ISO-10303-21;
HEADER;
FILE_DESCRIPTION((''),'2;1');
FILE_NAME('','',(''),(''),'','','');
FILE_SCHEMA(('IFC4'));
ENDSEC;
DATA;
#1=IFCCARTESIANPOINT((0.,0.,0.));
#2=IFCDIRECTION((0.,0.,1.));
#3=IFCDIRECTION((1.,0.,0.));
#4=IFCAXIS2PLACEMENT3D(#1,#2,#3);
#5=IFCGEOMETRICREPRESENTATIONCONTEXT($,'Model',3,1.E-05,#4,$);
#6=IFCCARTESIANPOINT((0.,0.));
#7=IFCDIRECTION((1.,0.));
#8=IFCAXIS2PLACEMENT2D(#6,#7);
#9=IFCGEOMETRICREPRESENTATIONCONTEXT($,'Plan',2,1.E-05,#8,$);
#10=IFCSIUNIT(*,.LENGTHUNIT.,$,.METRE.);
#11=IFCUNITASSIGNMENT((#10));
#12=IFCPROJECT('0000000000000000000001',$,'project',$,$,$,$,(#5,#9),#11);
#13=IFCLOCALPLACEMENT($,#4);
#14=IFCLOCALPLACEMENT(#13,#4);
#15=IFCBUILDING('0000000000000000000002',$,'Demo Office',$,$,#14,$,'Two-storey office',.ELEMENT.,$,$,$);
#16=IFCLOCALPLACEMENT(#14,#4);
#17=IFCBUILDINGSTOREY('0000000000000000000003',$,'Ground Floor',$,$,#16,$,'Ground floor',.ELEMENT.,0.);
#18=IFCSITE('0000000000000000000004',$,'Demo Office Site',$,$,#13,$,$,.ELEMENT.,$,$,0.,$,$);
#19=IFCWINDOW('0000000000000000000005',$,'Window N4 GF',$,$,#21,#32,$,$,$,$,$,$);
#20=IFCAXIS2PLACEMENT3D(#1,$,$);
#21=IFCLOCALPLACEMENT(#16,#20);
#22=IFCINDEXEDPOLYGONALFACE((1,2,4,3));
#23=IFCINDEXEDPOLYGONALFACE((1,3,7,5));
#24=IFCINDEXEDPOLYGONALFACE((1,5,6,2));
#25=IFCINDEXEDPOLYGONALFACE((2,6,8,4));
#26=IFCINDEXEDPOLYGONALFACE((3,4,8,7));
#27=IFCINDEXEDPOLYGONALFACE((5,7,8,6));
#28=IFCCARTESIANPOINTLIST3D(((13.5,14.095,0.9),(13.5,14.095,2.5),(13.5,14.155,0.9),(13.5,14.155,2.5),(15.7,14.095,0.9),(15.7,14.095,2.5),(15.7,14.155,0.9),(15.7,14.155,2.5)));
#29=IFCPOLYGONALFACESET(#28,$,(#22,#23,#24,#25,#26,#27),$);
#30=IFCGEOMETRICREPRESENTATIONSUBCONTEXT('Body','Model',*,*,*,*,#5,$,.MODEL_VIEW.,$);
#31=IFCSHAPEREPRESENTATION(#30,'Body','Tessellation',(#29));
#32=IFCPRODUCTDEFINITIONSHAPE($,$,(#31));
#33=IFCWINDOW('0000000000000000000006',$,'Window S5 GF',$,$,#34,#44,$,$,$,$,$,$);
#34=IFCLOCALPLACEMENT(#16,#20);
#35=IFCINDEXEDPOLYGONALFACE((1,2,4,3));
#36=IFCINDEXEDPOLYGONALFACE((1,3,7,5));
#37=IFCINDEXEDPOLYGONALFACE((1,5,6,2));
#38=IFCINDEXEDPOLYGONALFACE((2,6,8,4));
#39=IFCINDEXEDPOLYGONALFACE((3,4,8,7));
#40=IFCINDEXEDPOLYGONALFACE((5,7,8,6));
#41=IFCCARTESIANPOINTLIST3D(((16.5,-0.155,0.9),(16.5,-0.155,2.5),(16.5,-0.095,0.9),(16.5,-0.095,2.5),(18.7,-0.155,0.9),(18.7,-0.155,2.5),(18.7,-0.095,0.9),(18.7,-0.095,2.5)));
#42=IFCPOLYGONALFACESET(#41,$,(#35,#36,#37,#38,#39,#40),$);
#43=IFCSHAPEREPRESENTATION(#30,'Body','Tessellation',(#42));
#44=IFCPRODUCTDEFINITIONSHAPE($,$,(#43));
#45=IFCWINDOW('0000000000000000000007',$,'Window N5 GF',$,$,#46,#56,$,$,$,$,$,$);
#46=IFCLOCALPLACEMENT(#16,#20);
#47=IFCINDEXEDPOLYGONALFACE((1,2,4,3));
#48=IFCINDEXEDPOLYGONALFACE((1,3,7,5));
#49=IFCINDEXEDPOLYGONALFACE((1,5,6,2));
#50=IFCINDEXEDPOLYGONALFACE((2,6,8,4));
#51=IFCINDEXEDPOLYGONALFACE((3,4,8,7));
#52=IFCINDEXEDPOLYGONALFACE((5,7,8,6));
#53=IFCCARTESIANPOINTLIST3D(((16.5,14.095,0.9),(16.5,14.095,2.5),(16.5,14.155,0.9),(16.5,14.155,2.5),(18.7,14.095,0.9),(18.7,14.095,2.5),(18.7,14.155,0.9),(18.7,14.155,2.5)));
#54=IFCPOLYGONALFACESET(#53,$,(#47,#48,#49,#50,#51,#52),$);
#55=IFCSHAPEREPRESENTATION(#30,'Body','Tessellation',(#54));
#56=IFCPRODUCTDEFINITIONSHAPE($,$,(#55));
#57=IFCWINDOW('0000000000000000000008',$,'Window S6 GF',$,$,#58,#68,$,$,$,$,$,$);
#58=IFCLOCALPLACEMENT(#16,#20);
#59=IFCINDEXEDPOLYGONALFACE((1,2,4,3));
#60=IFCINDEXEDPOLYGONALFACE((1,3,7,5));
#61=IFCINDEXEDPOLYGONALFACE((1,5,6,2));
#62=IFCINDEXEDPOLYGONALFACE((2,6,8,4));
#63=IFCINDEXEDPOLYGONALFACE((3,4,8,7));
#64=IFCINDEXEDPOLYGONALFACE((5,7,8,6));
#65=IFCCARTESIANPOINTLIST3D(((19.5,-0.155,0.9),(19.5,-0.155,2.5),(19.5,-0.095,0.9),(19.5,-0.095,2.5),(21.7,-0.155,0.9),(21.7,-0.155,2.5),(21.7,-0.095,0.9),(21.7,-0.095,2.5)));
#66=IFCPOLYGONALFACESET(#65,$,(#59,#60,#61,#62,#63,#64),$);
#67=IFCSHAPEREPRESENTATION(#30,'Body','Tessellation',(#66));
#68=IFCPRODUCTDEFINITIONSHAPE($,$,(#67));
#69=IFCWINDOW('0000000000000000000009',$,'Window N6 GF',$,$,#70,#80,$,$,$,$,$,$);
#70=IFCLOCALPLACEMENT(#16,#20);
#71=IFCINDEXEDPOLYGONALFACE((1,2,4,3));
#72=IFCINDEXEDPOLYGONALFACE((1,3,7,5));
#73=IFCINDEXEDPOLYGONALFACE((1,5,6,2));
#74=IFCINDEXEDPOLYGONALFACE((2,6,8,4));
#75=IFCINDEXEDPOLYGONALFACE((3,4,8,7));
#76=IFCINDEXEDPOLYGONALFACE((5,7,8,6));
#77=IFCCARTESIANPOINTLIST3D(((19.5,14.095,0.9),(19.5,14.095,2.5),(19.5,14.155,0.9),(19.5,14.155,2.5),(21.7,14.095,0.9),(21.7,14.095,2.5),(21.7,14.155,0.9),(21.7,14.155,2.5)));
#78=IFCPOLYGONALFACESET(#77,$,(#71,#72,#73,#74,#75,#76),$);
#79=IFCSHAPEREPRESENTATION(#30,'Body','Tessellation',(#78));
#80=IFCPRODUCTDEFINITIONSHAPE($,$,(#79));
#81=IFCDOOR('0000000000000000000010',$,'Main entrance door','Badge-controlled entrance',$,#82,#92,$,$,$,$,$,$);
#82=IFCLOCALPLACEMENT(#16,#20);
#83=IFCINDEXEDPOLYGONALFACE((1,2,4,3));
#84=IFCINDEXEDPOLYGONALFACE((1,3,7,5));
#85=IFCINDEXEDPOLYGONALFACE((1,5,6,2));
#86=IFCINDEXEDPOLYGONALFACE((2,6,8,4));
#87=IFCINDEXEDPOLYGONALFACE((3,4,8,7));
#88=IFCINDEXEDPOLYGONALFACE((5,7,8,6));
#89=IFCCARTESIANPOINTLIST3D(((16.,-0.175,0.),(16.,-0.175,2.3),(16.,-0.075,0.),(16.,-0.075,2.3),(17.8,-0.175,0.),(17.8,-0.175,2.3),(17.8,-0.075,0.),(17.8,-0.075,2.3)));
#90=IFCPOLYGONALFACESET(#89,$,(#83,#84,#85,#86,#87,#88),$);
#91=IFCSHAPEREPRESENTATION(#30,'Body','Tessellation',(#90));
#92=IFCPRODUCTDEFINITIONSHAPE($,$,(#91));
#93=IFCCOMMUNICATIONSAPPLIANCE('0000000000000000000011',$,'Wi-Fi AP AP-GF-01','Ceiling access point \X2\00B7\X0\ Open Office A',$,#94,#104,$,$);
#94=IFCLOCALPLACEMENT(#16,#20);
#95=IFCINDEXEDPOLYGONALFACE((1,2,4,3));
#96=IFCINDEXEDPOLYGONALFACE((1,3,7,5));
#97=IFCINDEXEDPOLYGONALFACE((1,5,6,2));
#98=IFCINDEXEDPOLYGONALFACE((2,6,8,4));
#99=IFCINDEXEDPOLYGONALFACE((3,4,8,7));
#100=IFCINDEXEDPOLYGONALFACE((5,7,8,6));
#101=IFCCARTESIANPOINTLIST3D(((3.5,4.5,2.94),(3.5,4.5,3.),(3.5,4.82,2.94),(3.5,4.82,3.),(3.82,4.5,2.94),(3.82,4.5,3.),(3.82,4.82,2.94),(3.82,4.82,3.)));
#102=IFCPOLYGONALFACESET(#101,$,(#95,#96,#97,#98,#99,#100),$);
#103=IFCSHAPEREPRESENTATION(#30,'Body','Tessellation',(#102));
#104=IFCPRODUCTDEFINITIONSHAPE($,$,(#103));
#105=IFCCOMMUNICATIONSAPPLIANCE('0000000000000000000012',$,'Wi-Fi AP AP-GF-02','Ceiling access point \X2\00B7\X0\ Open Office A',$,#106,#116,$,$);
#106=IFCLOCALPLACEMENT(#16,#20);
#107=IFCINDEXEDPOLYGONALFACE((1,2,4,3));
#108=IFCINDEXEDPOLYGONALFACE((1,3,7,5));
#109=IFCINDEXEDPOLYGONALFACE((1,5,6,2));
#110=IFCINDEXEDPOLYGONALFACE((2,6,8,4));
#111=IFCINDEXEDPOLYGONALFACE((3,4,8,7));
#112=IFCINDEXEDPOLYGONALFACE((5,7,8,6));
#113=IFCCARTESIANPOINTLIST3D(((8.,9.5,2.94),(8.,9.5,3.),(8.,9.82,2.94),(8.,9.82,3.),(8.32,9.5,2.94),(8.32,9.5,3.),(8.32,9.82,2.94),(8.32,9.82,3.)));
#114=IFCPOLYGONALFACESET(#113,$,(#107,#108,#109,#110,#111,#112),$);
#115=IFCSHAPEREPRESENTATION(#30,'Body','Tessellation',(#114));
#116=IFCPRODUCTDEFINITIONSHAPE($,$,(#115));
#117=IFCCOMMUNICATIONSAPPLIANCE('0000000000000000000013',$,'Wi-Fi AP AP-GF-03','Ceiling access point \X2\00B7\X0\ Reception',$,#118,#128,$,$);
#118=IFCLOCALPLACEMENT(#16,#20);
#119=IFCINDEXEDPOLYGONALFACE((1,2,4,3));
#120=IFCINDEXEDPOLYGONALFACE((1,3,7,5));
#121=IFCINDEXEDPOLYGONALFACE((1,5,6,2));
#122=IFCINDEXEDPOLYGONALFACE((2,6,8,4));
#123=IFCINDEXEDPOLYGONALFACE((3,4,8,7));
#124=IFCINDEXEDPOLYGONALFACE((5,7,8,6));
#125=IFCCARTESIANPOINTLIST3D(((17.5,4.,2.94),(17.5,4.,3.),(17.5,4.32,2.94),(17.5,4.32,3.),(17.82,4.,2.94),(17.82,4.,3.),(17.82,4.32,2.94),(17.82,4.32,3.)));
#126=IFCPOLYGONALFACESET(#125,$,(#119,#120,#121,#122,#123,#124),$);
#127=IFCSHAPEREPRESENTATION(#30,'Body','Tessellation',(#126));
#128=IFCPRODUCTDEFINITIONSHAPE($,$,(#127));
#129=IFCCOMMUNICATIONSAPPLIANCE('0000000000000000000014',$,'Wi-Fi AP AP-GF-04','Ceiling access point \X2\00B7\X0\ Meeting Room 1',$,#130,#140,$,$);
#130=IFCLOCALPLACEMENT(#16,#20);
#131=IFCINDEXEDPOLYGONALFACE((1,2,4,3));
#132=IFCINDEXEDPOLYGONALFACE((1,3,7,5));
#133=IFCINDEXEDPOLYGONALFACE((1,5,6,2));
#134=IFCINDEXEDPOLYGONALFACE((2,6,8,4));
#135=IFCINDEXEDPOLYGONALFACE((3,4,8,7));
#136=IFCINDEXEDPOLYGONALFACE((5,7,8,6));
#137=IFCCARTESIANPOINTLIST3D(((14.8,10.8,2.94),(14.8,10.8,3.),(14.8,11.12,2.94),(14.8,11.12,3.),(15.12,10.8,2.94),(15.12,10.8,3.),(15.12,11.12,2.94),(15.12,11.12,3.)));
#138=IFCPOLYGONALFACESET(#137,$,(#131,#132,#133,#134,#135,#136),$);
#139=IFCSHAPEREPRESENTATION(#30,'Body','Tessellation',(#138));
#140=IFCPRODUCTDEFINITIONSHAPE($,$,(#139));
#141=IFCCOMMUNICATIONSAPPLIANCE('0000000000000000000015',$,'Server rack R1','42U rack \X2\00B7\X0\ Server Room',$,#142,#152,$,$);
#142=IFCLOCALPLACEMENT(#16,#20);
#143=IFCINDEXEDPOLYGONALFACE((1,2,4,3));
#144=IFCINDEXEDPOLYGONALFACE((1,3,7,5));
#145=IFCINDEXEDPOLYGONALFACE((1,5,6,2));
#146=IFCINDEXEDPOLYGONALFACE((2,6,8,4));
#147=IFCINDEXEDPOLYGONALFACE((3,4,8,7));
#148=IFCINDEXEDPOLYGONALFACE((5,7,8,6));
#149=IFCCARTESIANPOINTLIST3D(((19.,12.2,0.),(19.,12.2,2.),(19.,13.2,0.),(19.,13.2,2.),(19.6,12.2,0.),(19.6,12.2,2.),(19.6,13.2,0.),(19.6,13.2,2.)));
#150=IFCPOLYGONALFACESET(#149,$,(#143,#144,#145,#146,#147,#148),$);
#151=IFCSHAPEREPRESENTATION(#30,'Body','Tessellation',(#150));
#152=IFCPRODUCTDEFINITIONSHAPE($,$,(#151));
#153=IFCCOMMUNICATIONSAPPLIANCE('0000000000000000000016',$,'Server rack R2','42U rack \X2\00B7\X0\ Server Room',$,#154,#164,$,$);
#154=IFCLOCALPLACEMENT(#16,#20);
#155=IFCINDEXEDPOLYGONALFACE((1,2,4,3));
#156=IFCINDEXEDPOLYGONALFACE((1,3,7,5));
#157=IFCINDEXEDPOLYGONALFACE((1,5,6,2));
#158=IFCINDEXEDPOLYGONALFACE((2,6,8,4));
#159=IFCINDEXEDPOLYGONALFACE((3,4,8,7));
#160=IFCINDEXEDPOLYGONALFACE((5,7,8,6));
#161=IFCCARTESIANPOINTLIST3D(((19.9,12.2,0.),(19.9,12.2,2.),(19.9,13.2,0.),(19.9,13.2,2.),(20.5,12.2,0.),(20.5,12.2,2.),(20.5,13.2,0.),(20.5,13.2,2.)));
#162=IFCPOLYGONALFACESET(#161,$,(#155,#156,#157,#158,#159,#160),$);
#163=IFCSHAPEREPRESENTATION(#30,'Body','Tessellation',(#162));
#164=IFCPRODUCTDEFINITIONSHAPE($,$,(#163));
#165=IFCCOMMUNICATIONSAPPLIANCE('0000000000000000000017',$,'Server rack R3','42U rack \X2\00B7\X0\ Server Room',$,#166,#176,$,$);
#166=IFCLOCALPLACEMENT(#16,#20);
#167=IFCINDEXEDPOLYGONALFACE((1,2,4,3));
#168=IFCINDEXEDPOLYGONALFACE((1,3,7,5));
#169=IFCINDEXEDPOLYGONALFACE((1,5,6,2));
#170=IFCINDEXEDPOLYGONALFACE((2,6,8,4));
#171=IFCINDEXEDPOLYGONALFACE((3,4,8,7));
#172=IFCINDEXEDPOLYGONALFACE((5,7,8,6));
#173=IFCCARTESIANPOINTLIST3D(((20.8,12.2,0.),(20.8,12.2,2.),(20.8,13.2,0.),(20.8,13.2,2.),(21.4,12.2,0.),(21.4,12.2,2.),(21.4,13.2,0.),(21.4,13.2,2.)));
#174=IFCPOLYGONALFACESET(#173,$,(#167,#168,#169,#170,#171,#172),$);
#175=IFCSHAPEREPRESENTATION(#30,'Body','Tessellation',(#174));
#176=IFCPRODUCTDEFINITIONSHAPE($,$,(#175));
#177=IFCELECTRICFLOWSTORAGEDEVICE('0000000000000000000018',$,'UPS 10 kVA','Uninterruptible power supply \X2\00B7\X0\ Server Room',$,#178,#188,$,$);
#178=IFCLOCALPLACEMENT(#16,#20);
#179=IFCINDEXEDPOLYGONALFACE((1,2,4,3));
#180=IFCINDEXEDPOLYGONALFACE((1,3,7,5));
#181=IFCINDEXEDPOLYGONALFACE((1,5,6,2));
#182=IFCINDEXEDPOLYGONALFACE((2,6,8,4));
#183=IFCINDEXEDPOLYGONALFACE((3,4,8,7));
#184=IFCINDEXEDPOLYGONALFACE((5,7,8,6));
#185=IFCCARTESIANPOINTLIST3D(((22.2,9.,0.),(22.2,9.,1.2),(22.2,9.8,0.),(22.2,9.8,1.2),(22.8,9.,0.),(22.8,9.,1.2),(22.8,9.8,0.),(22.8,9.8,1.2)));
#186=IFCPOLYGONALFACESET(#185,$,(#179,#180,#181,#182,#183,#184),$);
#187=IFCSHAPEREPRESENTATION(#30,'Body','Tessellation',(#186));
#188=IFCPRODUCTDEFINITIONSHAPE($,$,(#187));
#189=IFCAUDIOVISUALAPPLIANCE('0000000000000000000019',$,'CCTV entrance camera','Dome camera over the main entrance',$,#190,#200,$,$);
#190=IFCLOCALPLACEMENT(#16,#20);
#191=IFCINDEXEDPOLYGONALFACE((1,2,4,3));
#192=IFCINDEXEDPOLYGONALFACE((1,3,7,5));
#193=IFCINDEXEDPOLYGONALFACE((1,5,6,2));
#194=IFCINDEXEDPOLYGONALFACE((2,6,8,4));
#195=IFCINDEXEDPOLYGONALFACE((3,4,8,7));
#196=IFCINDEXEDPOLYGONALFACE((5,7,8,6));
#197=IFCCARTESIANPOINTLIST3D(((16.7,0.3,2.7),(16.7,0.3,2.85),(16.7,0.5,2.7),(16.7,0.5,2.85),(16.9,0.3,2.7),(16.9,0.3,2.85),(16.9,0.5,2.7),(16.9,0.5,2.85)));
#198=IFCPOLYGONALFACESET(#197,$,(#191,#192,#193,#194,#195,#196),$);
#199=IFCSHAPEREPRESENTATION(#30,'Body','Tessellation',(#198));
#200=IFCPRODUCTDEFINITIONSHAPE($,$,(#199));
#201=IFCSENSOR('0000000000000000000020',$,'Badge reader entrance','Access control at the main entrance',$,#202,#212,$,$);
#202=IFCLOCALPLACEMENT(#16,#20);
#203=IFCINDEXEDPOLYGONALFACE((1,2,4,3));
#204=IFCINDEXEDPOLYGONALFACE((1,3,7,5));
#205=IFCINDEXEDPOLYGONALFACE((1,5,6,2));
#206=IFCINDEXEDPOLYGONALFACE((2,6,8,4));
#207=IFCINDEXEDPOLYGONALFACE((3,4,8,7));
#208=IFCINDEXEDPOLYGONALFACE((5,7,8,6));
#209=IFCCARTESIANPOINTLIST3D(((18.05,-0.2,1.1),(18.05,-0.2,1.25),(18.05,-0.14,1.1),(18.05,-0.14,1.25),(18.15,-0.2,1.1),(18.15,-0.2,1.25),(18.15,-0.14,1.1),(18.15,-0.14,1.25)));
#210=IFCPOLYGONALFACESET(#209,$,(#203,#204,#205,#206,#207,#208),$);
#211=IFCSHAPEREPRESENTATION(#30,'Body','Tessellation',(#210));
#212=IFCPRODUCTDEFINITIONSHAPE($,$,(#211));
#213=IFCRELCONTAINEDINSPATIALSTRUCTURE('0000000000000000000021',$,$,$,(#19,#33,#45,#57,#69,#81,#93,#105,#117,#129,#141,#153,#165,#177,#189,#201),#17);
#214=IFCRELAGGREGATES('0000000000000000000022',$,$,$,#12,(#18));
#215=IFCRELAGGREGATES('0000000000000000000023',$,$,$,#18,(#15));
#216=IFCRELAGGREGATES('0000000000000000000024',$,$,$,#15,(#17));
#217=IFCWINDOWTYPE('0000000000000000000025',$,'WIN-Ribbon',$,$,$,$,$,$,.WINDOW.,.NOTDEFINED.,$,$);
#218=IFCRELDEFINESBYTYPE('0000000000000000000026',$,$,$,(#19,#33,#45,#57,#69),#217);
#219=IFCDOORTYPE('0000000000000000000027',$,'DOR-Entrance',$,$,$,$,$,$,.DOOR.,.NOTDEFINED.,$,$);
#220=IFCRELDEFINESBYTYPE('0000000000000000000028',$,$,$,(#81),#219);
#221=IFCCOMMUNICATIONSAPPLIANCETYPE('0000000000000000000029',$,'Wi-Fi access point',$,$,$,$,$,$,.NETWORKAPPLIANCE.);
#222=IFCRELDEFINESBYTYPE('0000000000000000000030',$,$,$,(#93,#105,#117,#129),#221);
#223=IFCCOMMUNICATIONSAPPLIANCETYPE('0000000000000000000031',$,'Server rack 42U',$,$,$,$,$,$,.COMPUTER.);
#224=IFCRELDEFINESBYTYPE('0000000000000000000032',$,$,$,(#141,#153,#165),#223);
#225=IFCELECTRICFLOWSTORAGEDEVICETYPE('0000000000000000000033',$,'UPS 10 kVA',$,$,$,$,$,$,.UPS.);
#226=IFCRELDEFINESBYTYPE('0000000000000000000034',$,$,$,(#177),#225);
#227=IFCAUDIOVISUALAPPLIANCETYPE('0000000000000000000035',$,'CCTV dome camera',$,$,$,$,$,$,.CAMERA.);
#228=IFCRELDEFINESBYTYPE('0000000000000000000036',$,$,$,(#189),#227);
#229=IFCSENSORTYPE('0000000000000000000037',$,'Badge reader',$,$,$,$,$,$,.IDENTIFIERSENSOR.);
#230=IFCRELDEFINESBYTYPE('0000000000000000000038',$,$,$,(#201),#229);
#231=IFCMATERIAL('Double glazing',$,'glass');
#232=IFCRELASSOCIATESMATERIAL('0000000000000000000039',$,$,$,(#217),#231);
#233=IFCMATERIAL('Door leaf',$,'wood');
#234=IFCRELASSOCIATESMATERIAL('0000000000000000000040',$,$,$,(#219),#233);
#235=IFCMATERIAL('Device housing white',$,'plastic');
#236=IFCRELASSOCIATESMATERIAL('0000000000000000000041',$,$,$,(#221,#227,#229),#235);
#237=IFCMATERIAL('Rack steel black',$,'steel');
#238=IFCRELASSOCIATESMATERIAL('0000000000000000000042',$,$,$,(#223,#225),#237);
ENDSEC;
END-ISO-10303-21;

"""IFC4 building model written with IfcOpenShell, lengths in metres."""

from ifc_helpers import new_model, si_unit, frame, origin_with_axes, origin_2d_with_axis, place, context, subcontext, project, spatial, line, indexed_curve, outline, extrude, material, type_object, element, save


model = new_model("IFC4")

# Units and contexts
model_context = context("Model", 3, precision=1e-05, world=origin_with_axes())
plan_context = context("Plan", 2, precision=1e-05, world=origin_2d_with_axis())
body_context = subcontext(model_context, "Body", "Model", "MODEL_VIEW")
ifc_project = project(units=[si_unit("LENGTHUNIT", "METRE")], contexts=[model_context, plan_context])

# Site, building, storey
site_placement = place(None, origin_with_axes())
site = spatial("IfcSite", under=ifc_project, at=site_placement, Name="Demo Office Site", CompositionType="ELEMENT", RefElevation=0.0)
building_placement = place(site_placement, origin_with_axes())
building = spatial("IfcBuilding", under=site, at=building_placement, Name="Demo Office", LongName="Two-storey office", CompositionType="ELEMENT")
storey_placement = place(building_placement, origin_with_axes())
storey = spatial("IfcBuildingStorey", under=building, at=storey_placement, Name="Ground Floor", LongName="Ground floor", CompositionType="ELEMENT", Elevation=0.0)

# Windows
ifc_material_1 = material(Name="Double glazing", Category="glass")
window_type = type_object("IfcWindowType", Name="WIN-Ribbon", PartitioningType="NOTDEFINED", PredefinedType="WINDOW", material=ifc_material_1)
for number, where, z_axis, x_axis, name in (
    (1, (13.5, 14.095, 0.9), (0.0, 0.0, 1.0), (1.0, 0.0, 0.0), "Window N4 GF"),
    (2, (16.5, -0.155, 0.9), (0.0, 0.0, 1.0), (1.0, 0.0, 0.0), "Window S5 GF"),
    (3, (16.5, 14.095, 0.9), (0.0, 0.0, 1.0), (1.0, 0.0, 0.0), "Window N5 GF"),
    (4, (19.5, -0.155, 0.9), (0.0, 0.0, 1.0), (1.0, 0.0, 0.0), "Window S6 GF"),
    (5, (19.5, 14.095, 0.9), (0.0, 0.0, 1.0), (1.0, 0.0, 0.0), "Window N6 GF"),
):
    element("IfcWindow", number, at=place(storey_placement, frame(where, z_axis=z_axis, x_axis=x_axis)), inside=storey, type_object=window_type, Name=name, context=body_context, shape_type="SweptSolid", body=[
        extrude(outline(indexed_curve([(0.0, 0.0), (2.2, 0.0), (2.2, 0.06), (0.0, 0.06)], segments=[line(1, 2, 3, 4, 1)])), origin_with_axes(), (0.0, 0.0, 1.0), 1.6),
    ])

# Door
ifc_material_2 = material(Name="Door leaf", Category="wood")
door_type = type_object("IfcDoorType", Name="DOR-Entrance", OperationType="NOTDEFINED", PredefinedType="DOOR", material=ifc_material_2)
door_placement = place(storey_placement, frame((16.0, -0.175, 0.0), z_axis=(0.0, 0.0, 1.0), x_axis=(1.0, 0.0, 0.0)))
element("IfcDoor", 6, at=door_placement, inside=storey, type_object=door_type, Name="Main entrance door", Description="Badge-controlled entrance", context=body_context, shape_type="SweptSolid", body=[
    extrude(outline(indexed_curve([(0.0, 0.0), (1.8, 0.0), (1.8, 0.1), (0.0, 0.1)], segments=[line(1, 2, 3, 4, 1)])), origin_with_axes(), (0.0, 0.0, 1.0), 2.3),
])

# Communications appliances
ifc_material_3 = material(Name="Device housing white", Category="plastic")
communications_appliance_type_1 = type_object("IfcCommunicationsApplianceType", Name="Wi-Fi access point", PredefinedType="NETWORKAPPLIANCE", material=ifc_material_3)
for number, where, z_axis, x_axis, name, description in (
    (7, (3.5, 4.5, 2.94), (0.0, 0.0, 1.0), (1.0, 0.0, 0.0), "Wi-Fi AP AP-GF-01", "Ceiling access point · Open Office A"),
    (8, (8.0, 9.5, 2.94), (0.0, 0.0, 1.0), (1.0, 0.0, 0.0), "Wi-Fi AP AP-GF-02", "Ceiling access point · Open Office A"),
    (9, (17.5, 4.0, 2.94), (0.0, 0.0, 1.0), (1.0, 0.0, 0.0), "Wi-Fi AP AP-GF-03", "Ceiling access point · Reception"),
    (10, (14.8, 10.8, 2.94), (0.0, 0.0, 1.0), (1.0, 0.0, 0.0), "Wi-Fi AP AP-GF-04", "Ceiling access point · Meeting Room 1"),
):
    element("IfcCommunicationsAppliance", number, at=place(storey_placement, frame(where, z_axis=z_axis, x_axis=x_axis)), inside=storey, type_object=communications_appliance_type_1, Name=name, Description=description, context=body_context, shape_type="SweptSolid", body=[
        extrude(outline(indexed_curve([(0.0, 0.0), (0.32, 0.0), (0.32, 0.32), (0.0, 0.32)], segments=[line(1, 2, 3, 4, 1)])), origin_with_axes(), (0.0, 0.0, 1.0), 0.06),
    ])
ifc_material_4 = material(Name="Rack steel black", Category="steel")
communications_appliance_type_2 = type_object("IfcCommunicationsApplianceType", Name="Server rack 42U", PredefinedType="COMPUTER", material=ifc_material_4)
for number, where, z_axis, x_axis, name in (
    (11, (19.0, 12.2, 0.0), (0.0, 0.0, 1.0), (1.0, 0.0, 0.0), "Server rack R1"),
    (12, (19.9, 12.2, 0.0), (0.0, 0.0, 1.0), (1.0, 0.0, 0.0), "Server rack R2"),
    (13, (20.8, 12.2, 0.0), (0.0, 0.0, 1.0), (1.0, 0.0, 0.0), "Server rack R3"),
):
    element("IfcCommunicationsAppliance", number, at=place(storey_placement, frame(where, z_axis=z_axis, x_axis=x_axis)), inside=storey, type_object=communications_appliance_type_2, Name=name, Description="42U rack · Server Room", context=body_context, shape_type="SweptSolid", body=[
        extrude(outline(indexed_curve([(0.0, 0.0), (0.6, 0.0), (0.6, 1.0), (0.0, 1.0)], segments=[line(1, 2, 3, 4, 1)])), origin_with_axes(), (0.0, 0.0, 1.0), 2.0),
    ])

# Electric flow storage device
electric_flow_storage_device_type = type_object("IfcElectricFlowStorageDeviceType", Name="UPS 10 kVA", PredefinedType="UPS", material=ifc_material_4)
electric_flow_storage_device_placement = place(storey_placement, frame((22.2, 9.0, 0.0), z_axis=(0.0, 0.0, 1.0), x_axis=(1.0, 0.0, 0.0)))
element("IfcElectricFlowStorageDevice", 14, at=electric_flow_storage_device_placement, inside=storey, type_object=electric_flow_storage_device_type, Name="UPS 10 kVA", Description="Uninterruptible power supply · Server Room", context=body_context, shape_type="SweptSolid", body=[
    extrude(outline(indexed_curve([(0.0, 0.0), (0.6, 0.0), (0.6, 0.8), (0.0, 0.8)], segments=[line(1, 2, 3, 4, 1)])), origin_with_axes(), (0.0, 0.0, 1.0), 1.2),
])

# Audio visual appliance
audio_visual_appliance_type = type_object("IfcAudioVisualApplianceType", Name="CCTV dome camera", PredefinedType="CAMERA", material=ifc_material_3)
audio_visual_appliance_placement = place(storey_placement, frame((16.7, 0.3, 2.7), z_axis=(0.0, 0.0, 1.0), x_axis=(1.0, 0.0, 0.0)))
element("IfcAudioVisualAppliance", 15, at=audio_visual_appliance_placement, inside=storey, type_object=audio_visual_appliance_type, Name="CCTV entrance camera", Description="Dome camera over the main entrance", context=body_context, shape_type="SweptSolid", body=[
    extrude(outline(indexed_curve([(0.0, 0.0), (0.2, 0.0), (0.2, 0.2), (0.0, 0.2)], segments=[line(1, 2, 3, 4, 1)])), origin_with_axes(), (0.0, 0.0, 1.0), 0.15),
])

# Sensor
sensor_type = type_object("IfcSensorType", Name="Badge reader", PredefinedType="IDENTIFIERSENSOR", material=ifc_material_3)
sensor_placement = place(storey_placement, frame((18.05, -0.2, 1.1), z_axis=(0.0, 0.0, 1.0), x_axis=(1.0, 0.0, 0.0)))
element("IfcSensor", 16, at=sensor_placement, inside=storey, type_object=sensor_type, Name="Badge reader entrance", Description="Access control at the main entrance", context=body_context, shape_type="SweptSolid", body=[
    extrude(outline(indexed_curve([(0.0, 0.0), (0.1, 0.0), (0.1, 0.06), (0.0, 0.06)], segments=[line(1, 2, 3, 4, 1)])), origin_with_axes(), (0.0, 0.0, 1.0), 0.15),
])

save(model, "model.ifc")
